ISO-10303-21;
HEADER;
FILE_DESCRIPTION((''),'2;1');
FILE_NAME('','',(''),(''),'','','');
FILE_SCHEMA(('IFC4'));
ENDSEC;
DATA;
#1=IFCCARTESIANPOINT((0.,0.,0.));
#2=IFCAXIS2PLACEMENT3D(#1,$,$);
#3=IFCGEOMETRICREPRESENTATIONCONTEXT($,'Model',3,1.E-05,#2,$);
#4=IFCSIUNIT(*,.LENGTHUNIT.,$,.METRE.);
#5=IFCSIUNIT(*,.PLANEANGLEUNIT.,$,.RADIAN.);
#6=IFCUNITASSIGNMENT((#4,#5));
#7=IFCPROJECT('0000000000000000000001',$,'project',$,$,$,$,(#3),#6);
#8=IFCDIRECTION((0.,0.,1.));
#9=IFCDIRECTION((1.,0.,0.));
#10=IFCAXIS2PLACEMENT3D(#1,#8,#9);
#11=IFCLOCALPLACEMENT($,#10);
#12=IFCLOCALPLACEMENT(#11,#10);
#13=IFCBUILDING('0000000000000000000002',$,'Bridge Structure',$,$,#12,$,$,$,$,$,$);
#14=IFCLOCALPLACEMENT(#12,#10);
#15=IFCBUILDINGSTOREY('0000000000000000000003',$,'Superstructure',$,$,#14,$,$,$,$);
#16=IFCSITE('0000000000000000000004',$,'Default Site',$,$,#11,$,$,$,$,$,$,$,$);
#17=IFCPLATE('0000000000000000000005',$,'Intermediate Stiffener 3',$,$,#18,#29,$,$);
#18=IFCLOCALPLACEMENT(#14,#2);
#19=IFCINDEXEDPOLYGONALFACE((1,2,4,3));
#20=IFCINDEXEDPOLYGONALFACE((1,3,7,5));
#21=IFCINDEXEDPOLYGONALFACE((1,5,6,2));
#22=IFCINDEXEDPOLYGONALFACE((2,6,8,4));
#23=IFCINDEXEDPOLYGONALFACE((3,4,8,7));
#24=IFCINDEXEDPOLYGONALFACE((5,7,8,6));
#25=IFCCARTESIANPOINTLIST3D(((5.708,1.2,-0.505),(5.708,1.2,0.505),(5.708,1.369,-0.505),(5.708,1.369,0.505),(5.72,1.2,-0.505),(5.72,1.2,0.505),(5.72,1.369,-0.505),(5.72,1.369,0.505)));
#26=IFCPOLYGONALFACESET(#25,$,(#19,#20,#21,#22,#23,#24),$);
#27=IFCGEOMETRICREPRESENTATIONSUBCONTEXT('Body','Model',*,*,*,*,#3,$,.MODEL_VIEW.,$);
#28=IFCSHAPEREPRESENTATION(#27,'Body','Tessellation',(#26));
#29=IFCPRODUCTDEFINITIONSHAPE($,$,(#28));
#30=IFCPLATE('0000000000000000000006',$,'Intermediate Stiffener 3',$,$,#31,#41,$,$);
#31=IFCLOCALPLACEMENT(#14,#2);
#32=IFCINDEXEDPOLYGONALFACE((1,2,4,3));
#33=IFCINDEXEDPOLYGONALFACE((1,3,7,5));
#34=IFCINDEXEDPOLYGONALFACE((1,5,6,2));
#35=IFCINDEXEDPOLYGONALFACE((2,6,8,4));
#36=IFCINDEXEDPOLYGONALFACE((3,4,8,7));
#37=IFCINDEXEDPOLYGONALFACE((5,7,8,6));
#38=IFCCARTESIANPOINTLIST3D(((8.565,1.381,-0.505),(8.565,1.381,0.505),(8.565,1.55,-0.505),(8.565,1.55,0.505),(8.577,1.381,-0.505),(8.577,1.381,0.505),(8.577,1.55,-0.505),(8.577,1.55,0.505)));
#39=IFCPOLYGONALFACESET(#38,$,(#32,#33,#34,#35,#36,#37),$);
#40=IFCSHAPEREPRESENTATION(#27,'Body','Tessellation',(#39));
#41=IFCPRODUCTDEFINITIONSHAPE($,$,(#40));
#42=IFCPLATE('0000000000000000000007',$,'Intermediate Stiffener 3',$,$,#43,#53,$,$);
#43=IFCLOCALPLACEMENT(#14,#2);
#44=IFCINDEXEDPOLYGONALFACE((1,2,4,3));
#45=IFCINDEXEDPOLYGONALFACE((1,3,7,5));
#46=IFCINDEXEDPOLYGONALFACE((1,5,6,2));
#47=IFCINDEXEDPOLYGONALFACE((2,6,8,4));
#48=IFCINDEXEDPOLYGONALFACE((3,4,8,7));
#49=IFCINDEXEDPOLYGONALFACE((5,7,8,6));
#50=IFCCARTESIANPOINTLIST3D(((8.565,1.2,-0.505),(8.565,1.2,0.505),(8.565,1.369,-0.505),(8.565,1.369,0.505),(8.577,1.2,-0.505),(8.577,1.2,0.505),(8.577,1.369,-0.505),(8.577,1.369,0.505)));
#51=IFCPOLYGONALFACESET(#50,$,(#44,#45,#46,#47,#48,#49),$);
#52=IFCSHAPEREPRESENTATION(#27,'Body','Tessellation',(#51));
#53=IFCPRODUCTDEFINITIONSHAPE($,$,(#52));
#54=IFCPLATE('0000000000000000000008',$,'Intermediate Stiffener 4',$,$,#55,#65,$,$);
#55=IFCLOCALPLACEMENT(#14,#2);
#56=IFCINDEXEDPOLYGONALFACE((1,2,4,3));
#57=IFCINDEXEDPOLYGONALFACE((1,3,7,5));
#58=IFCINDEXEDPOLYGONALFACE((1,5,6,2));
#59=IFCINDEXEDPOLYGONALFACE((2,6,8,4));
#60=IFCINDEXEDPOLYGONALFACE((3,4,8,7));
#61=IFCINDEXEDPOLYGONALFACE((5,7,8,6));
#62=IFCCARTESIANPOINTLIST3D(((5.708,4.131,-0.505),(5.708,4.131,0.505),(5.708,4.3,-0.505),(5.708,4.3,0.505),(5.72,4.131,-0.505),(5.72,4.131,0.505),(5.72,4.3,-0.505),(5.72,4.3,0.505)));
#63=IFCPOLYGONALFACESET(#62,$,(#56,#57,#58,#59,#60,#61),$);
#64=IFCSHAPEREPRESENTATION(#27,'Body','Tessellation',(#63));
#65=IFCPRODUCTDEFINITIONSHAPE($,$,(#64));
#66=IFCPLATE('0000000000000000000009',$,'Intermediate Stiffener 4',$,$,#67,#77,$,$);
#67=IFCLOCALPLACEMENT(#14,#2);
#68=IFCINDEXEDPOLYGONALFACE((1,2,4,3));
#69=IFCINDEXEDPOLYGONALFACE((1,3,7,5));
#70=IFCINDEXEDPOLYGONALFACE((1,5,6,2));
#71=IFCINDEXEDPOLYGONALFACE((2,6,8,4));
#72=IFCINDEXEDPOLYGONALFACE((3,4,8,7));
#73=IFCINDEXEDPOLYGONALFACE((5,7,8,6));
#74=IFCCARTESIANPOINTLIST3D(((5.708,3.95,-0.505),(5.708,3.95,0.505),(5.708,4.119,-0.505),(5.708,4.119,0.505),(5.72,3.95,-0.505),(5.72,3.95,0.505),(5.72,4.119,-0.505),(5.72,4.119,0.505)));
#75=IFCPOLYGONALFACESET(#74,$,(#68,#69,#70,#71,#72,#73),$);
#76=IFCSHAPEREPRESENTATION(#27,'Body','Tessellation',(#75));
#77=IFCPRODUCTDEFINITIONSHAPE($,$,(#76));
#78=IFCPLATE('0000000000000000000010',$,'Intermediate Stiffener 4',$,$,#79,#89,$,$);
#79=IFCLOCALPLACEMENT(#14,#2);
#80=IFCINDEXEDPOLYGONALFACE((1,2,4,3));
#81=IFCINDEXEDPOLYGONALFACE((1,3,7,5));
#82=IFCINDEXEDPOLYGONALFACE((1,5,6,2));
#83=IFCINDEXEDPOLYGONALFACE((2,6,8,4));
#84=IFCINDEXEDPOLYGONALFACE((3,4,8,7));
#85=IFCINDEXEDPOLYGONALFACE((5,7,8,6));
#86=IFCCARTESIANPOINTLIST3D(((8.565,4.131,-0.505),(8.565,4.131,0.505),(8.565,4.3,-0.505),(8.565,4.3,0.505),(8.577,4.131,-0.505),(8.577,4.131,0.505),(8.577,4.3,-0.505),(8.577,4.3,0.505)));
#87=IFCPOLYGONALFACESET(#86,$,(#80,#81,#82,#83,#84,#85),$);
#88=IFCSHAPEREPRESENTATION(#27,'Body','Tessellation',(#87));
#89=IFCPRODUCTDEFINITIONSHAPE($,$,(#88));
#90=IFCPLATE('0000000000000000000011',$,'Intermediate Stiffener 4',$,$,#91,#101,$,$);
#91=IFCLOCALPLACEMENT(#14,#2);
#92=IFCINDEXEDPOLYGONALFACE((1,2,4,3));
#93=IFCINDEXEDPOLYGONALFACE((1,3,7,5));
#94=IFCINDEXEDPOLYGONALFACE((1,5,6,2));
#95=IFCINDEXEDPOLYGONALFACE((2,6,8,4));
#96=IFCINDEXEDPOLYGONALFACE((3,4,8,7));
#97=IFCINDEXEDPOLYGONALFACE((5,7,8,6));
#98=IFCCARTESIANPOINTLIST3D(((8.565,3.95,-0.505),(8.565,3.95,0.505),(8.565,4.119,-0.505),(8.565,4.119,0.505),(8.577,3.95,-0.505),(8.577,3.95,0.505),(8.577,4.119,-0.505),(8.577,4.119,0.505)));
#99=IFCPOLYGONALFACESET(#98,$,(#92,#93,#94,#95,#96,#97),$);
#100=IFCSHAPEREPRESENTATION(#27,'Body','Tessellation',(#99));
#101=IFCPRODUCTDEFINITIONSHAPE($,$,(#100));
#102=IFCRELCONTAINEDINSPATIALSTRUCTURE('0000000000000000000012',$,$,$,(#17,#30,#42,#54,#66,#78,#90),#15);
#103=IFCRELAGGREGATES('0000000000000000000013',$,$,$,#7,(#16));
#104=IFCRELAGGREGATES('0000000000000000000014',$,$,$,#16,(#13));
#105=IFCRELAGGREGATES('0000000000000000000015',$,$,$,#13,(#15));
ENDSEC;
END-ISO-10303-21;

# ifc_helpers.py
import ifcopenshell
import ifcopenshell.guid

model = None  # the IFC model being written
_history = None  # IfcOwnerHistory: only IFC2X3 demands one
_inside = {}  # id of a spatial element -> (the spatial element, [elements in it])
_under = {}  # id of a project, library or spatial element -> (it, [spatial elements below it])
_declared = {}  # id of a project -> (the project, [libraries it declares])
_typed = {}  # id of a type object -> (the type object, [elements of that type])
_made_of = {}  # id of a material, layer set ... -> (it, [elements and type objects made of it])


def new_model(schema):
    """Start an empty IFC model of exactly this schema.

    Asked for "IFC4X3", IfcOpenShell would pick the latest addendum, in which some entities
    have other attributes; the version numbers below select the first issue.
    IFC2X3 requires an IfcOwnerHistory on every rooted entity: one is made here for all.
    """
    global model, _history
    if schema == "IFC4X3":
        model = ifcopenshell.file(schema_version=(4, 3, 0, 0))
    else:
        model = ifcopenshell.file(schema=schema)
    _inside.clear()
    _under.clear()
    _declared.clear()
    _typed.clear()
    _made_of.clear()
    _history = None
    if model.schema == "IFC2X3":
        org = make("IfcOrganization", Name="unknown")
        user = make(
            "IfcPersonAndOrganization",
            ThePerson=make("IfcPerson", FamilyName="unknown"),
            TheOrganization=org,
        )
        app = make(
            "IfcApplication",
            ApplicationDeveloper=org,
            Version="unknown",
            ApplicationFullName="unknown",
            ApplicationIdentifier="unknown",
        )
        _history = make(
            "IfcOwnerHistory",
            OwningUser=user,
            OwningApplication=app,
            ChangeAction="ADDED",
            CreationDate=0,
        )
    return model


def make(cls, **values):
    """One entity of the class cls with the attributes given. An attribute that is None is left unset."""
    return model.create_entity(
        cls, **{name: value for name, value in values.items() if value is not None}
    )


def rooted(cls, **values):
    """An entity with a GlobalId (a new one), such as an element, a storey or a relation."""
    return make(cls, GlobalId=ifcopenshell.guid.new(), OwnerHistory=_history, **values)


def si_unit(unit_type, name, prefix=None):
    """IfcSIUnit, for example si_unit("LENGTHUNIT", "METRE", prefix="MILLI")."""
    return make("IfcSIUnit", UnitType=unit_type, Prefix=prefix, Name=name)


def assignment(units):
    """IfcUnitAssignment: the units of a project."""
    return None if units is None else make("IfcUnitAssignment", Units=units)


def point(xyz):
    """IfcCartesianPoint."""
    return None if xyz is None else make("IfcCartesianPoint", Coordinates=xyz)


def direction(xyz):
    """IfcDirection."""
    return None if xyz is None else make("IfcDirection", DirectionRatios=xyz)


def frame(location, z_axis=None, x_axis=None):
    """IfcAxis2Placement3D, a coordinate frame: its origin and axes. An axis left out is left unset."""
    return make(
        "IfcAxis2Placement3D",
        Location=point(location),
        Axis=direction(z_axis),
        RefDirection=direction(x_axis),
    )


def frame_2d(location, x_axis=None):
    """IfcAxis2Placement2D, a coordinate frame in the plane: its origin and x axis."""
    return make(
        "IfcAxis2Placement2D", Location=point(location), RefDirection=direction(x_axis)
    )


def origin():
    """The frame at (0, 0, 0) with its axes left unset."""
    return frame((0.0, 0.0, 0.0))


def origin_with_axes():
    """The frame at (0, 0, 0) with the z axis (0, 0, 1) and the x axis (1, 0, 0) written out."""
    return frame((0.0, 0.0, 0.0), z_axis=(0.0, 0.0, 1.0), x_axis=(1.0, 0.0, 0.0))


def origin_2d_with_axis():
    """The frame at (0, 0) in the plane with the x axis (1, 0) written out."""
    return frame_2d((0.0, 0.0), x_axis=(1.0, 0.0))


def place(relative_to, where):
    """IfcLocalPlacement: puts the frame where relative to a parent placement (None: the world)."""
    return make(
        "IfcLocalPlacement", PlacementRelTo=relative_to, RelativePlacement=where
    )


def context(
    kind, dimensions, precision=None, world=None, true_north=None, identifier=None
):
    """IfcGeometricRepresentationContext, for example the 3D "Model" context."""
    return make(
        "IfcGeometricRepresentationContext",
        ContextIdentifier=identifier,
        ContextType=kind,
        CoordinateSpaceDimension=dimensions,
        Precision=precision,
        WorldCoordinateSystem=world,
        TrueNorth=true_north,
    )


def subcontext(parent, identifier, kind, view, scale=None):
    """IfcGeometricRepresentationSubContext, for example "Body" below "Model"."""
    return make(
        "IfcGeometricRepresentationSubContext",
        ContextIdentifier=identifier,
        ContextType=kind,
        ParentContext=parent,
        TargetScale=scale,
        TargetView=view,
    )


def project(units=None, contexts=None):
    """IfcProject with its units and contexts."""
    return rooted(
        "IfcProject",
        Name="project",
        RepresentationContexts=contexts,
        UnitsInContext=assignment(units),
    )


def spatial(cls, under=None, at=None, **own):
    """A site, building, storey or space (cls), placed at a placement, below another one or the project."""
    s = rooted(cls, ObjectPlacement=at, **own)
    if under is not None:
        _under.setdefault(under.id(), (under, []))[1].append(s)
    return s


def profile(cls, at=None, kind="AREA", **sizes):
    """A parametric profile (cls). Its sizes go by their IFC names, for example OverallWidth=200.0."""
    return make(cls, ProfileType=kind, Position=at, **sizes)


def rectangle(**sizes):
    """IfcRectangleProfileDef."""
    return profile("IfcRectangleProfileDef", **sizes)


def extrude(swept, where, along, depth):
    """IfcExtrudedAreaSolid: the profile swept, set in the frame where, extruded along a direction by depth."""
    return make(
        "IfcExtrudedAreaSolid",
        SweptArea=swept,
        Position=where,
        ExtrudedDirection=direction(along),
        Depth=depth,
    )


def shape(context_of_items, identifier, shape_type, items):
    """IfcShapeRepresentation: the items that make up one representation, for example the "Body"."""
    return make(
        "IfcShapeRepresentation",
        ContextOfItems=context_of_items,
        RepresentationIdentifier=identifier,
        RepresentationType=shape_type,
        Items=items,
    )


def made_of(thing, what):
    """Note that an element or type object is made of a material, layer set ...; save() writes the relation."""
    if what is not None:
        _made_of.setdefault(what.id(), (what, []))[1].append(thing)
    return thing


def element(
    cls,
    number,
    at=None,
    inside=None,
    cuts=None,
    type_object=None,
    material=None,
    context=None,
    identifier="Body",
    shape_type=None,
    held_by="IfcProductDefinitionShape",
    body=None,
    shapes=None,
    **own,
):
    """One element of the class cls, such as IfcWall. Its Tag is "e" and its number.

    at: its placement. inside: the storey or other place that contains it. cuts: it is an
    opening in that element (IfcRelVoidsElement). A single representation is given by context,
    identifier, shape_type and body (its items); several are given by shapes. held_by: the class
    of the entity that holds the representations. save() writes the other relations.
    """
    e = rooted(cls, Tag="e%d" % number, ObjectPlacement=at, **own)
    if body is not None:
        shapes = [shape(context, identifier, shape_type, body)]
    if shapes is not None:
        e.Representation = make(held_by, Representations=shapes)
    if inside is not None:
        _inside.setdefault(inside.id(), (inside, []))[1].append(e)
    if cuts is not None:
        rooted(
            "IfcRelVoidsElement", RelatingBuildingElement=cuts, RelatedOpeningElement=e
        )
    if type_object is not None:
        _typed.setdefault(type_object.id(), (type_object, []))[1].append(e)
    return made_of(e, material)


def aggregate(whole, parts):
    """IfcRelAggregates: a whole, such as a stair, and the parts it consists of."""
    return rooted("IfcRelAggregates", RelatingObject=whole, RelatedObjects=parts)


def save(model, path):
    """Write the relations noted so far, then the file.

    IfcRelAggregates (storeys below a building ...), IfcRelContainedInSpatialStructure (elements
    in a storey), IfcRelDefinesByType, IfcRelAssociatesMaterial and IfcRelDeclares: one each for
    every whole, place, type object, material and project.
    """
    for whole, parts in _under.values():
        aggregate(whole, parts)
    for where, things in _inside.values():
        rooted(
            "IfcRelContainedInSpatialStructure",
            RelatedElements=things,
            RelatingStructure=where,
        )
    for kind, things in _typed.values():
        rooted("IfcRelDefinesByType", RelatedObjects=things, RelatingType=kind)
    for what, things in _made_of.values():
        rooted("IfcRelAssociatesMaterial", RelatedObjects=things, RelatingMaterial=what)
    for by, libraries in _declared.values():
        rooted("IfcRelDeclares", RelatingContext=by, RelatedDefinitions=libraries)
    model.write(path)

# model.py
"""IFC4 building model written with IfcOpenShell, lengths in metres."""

from ifc_helpers import new_model, si_unit, frame, origin, origin_with_axes, origin_2d_with_axis, place, context, subcontext, project, spatial, rectangle, extrude, element, save


model = new_model("IFC4")

# Units and contexts
model_context = context("Model", 3, precision=1e-05, world=origin())
body_context = subcontext(model_context, "Body", "Model", "MODEL_VIEW")
ifc_project = project(units=[si_unit("LENGTHUNIT", "METRE"), si_unit("PLANEANGLEUNIT", "RADIAN")], contexts=[model_context])

# Site, building, storey
site_placement = place(None, origin_with_axes())
site = spatial("IfcSite", under=ifc_project, at=site_placement, Name="Default Site")
building_placement = place(site_placement, origin_with_axes())
building = spatial("IfcBuilding", under=site, at=building_placement, Name="Bridge Structure")
storey_placement = place(building_placement, origin_with_axes())
storey = spatial("IfcBuildingStorey", under=building, at=storey_placement, Name="Superstructure")

# Plates
for number, where, z_axis, x_axis, name in (
    (1, (5.714, 1.2845, -0.505), (0.0, 0.0, 1.0), (1.0, 0.0, 0.0), "Intermediate Stiffener 3"),
    (2, (8.571, 1.4655, -0.505), (0.0, 0.0, 1.0), (1.0, 0.0, 0.0), "Intermediate Stiffener 3"),
    (3, (8.571, 1.2845, -0.505), (0.0, 0.0, 1.0), (1.0, 0.0, 0.0), "Intermediate Stiffener 3"),
    (4, (5.714, 4.2155, -0.505), (0.0, 0.0, 1.0), (1.0, 0.0, 0.0), "Intermediate Stiffener 4"),
    (5, (5.714, 4.0345, -0.505), (0.0, 0.0, 1.0), (1.0, 0.0, 0.0), "Intermediate Stiffener 4"),
    (6, (8.571, 4.2155, -0.505), (0.0, 0.0, 1.0), (1.0, 0.0, 0.0), "Intermediate Stiffener 4"),
    (7, (8.571, 4.0345, -0.505), (0.0, 0.0, 1.0), (1.0, 0.0, 0.0), "Intermediate Stiffener 4"),
):
    element("IfcPlate", number, at=place(storey_placement, frame(where, z_axis=z_axis, x_axis=x_axis)), inside=storey, Name=name, context=body_context, shape_type="SweptSolid", body=[
        extrude(rectangle(XDim=0.012, YDim=0.169, at=origin_2d_with_axis()), origin_with_axes(), (0.0, 0.0, 1.0), 1.01),
    ])

save(model, "model.ifc")
